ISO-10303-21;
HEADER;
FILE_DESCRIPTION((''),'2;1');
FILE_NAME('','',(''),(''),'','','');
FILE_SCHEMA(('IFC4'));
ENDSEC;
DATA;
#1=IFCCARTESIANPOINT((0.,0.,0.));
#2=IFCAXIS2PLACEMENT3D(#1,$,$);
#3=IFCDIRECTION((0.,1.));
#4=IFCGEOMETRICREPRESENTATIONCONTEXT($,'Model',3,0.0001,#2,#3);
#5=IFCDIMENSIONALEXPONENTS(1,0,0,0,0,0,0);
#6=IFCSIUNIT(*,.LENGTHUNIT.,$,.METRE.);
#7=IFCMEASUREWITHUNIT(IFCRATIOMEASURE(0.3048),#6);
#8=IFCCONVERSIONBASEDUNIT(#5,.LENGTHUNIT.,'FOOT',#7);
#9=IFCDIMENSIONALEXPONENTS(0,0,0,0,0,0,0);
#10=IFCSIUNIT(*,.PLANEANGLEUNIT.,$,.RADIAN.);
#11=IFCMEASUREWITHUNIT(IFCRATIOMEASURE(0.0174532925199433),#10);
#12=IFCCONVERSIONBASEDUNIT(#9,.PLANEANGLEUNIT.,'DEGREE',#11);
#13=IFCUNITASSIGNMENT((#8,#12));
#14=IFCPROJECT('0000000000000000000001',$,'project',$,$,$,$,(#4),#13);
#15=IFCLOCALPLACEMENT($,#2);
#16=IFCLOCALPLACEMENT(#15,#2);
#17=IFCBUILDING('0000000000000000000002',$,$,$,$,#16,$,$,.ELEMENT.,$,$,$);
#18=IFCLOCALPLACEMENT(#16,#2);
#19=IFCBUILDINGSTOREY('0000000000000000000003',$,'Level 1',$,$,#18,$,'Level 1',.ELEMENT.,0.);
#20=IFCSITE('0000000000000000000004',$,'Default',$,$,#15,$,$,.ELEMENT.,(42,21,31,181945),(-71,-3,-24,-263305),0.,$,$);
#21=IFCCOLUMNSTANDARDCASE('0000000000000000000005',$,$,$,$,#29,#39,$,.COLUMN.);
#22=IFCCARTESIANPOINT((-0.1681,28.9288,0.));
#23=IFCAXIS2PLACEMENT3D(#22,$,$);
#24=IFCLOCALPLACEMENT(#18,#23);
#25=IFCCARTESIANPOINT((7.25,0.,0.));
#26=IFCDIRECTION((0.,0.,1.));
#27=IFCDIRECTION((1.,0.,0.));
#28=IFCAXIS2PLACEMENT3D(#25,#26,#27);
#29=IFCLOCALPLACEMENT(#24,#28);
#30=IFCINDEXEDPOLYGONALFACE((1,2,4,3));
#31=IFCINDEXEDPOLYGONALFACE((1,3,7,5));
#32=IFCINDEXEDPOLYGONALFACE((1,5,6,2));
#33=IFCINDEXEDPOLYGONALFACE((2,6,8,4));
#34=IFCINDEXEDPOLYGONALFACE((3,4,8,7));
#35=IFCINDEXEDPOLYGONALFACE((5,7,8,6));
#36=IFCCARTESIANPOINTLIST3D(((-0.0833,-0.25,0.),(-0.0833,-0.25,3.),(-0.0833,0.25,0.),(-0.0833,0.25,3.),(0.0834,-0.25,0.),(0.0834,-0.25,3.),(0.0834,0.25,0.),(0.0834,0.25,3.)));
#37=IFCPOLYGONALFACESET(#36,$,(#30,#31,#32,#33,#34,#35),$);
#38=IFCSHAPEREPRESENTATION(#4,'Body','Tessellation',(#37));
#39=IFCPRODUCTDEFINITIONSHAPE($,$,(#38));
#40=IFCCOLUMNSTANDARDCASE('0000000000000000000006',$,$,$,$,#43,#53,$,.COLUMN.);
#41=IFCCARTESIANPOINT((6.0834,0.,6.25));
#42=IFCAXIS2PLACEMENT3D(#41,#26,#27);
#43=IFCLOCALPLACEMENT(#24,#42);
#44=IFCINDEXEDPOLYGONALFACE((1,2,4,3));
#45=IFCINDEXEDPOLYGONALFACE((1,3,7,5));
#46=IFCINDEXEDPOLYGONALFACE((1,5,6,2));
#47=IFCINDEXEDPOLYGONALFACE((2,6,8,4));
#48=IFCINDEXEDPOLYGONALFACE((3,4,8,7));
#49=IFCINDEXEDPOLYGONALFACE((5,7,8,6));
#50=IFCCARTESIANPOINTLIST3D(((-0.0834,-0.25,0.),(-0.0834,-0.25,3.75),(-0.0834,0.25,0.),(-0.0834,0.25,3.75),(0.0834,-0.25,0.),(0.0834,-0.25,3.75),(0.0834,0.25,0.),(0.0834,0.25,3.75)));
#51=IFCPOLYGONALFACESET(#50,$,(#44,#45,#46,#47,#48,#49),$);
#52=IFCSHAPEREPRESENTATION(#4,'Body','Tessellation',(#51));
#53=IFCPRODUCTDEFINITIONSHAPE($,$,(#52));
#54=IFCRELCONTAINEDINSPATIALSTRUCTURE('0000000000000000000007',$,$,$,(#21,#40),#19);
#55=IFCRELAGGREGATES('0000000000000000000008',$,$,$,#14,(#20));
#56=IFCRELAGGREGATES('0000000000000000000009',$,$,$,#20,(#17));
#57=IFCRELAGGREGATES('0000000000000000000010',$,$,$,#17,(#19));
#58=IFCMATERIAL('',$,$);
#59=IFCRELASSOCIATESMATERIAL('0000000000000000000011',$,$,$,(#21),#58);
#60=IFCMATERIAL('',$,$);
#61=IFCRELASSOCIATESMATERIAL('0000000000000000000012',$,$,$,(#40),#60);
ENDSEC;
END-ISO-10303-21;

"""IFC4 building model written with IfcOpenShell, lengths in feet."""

from ifc_helpers import new_model, entity, si_unit, converted_unit, direction, frame, origin, place, context, project, spatial, rectangle, extrude, material, element, save


model = new_model("IFC4")

# Units and contexts
model_context = context("Model", 3, precision=0.0001, world=origin(), true_north=direction((0.0, 1.0)))
ifc_project = project(units=[converted_unit("LENGTHUNIT", "FOOT", entity("IfcRatioMeasure", 0.3048), si_unit("LENGTHUNIT", "METRE"), dimensions=[1, 0, 0, 0, 0, 0, 0]), converted_unit("PLANEANGLEUNIT", "DEGREE", entity("IfcRatioMeasure", 0.0174532925199433), si_unit("PLANEANGLEUNIT", "RADIAN"), dimensions=[0, 0, 0, 0, 0, 0, 0])], contexts=[model_context])

# Site, building, storey
site_placement = place(None, origin())
site = spatial("IfcSite", under=ifc_project, at=site_placement, Name="Default", CompositionType="ELEMENT", RefLatitude=(42, 21, 31, 181945), RefLongitude=(-71, -3, -24, -263305), RefElevation=0.0)
building_placement = place(site_placement, origin())
building = spatial("IfcBuilding", under=site, at=building_placement, CompositionType="ELEMENT")
storey_placement = place(building_placement, origin())
storey = spatial("IfcBuildingStorey", under=building, at=storey_placement, Name="Level 1", LongName="Level 1", CompositionType="ELEMENT", Elevation=0.0)

# Columns
ifc_material_1 = material(Name="")
placement = place(storey_placement, frame((-0.1681, 28.9288, 0.0)))
for number, where, z_axis, x_axis in (
    (1, (7.25, 0.0, 0.0), (0.0, 0.0, 1.0), (1.0, 0.0, 0.0)),
):
    element("IfcColumnStandardCase", number, at=place(placement, frame(where, z_axis=z_axis, x_axis=x_axis)), inside=storey, material=ifc_material_1, PredefinedType="COLUMN", context=model_context, shape_type="SweptSolid", body=[
        extrude(rectangle(XDim=0.1667, YDim=0.5), origin(), (0.0, 0.0, 1.0), 3.0),
    ])
ifc_material_2 = material(Name="")
for number, where, z_axis, x_axis in (
    (2, (6.0834, 0.0, 6.25), (0.0, 0.0, 1.0), (1.0, 0.0, 0.0)),
):
    element("IfcColumnStandardCase", number, at=place(placement, frame(where, z_axis=z_axis, x_axis=x_axis)), inside=storey, material=ifc_material_2, PredefinedType="COLUMN", context=model_context, shape_type="SweptSolid", body=[
        extrude(rectangle(XDim=0.1667, YDim=0.5), origin(), (0.0, 0.0, 1.0), 3.75),
    ])

save(model, "model.ifc")
